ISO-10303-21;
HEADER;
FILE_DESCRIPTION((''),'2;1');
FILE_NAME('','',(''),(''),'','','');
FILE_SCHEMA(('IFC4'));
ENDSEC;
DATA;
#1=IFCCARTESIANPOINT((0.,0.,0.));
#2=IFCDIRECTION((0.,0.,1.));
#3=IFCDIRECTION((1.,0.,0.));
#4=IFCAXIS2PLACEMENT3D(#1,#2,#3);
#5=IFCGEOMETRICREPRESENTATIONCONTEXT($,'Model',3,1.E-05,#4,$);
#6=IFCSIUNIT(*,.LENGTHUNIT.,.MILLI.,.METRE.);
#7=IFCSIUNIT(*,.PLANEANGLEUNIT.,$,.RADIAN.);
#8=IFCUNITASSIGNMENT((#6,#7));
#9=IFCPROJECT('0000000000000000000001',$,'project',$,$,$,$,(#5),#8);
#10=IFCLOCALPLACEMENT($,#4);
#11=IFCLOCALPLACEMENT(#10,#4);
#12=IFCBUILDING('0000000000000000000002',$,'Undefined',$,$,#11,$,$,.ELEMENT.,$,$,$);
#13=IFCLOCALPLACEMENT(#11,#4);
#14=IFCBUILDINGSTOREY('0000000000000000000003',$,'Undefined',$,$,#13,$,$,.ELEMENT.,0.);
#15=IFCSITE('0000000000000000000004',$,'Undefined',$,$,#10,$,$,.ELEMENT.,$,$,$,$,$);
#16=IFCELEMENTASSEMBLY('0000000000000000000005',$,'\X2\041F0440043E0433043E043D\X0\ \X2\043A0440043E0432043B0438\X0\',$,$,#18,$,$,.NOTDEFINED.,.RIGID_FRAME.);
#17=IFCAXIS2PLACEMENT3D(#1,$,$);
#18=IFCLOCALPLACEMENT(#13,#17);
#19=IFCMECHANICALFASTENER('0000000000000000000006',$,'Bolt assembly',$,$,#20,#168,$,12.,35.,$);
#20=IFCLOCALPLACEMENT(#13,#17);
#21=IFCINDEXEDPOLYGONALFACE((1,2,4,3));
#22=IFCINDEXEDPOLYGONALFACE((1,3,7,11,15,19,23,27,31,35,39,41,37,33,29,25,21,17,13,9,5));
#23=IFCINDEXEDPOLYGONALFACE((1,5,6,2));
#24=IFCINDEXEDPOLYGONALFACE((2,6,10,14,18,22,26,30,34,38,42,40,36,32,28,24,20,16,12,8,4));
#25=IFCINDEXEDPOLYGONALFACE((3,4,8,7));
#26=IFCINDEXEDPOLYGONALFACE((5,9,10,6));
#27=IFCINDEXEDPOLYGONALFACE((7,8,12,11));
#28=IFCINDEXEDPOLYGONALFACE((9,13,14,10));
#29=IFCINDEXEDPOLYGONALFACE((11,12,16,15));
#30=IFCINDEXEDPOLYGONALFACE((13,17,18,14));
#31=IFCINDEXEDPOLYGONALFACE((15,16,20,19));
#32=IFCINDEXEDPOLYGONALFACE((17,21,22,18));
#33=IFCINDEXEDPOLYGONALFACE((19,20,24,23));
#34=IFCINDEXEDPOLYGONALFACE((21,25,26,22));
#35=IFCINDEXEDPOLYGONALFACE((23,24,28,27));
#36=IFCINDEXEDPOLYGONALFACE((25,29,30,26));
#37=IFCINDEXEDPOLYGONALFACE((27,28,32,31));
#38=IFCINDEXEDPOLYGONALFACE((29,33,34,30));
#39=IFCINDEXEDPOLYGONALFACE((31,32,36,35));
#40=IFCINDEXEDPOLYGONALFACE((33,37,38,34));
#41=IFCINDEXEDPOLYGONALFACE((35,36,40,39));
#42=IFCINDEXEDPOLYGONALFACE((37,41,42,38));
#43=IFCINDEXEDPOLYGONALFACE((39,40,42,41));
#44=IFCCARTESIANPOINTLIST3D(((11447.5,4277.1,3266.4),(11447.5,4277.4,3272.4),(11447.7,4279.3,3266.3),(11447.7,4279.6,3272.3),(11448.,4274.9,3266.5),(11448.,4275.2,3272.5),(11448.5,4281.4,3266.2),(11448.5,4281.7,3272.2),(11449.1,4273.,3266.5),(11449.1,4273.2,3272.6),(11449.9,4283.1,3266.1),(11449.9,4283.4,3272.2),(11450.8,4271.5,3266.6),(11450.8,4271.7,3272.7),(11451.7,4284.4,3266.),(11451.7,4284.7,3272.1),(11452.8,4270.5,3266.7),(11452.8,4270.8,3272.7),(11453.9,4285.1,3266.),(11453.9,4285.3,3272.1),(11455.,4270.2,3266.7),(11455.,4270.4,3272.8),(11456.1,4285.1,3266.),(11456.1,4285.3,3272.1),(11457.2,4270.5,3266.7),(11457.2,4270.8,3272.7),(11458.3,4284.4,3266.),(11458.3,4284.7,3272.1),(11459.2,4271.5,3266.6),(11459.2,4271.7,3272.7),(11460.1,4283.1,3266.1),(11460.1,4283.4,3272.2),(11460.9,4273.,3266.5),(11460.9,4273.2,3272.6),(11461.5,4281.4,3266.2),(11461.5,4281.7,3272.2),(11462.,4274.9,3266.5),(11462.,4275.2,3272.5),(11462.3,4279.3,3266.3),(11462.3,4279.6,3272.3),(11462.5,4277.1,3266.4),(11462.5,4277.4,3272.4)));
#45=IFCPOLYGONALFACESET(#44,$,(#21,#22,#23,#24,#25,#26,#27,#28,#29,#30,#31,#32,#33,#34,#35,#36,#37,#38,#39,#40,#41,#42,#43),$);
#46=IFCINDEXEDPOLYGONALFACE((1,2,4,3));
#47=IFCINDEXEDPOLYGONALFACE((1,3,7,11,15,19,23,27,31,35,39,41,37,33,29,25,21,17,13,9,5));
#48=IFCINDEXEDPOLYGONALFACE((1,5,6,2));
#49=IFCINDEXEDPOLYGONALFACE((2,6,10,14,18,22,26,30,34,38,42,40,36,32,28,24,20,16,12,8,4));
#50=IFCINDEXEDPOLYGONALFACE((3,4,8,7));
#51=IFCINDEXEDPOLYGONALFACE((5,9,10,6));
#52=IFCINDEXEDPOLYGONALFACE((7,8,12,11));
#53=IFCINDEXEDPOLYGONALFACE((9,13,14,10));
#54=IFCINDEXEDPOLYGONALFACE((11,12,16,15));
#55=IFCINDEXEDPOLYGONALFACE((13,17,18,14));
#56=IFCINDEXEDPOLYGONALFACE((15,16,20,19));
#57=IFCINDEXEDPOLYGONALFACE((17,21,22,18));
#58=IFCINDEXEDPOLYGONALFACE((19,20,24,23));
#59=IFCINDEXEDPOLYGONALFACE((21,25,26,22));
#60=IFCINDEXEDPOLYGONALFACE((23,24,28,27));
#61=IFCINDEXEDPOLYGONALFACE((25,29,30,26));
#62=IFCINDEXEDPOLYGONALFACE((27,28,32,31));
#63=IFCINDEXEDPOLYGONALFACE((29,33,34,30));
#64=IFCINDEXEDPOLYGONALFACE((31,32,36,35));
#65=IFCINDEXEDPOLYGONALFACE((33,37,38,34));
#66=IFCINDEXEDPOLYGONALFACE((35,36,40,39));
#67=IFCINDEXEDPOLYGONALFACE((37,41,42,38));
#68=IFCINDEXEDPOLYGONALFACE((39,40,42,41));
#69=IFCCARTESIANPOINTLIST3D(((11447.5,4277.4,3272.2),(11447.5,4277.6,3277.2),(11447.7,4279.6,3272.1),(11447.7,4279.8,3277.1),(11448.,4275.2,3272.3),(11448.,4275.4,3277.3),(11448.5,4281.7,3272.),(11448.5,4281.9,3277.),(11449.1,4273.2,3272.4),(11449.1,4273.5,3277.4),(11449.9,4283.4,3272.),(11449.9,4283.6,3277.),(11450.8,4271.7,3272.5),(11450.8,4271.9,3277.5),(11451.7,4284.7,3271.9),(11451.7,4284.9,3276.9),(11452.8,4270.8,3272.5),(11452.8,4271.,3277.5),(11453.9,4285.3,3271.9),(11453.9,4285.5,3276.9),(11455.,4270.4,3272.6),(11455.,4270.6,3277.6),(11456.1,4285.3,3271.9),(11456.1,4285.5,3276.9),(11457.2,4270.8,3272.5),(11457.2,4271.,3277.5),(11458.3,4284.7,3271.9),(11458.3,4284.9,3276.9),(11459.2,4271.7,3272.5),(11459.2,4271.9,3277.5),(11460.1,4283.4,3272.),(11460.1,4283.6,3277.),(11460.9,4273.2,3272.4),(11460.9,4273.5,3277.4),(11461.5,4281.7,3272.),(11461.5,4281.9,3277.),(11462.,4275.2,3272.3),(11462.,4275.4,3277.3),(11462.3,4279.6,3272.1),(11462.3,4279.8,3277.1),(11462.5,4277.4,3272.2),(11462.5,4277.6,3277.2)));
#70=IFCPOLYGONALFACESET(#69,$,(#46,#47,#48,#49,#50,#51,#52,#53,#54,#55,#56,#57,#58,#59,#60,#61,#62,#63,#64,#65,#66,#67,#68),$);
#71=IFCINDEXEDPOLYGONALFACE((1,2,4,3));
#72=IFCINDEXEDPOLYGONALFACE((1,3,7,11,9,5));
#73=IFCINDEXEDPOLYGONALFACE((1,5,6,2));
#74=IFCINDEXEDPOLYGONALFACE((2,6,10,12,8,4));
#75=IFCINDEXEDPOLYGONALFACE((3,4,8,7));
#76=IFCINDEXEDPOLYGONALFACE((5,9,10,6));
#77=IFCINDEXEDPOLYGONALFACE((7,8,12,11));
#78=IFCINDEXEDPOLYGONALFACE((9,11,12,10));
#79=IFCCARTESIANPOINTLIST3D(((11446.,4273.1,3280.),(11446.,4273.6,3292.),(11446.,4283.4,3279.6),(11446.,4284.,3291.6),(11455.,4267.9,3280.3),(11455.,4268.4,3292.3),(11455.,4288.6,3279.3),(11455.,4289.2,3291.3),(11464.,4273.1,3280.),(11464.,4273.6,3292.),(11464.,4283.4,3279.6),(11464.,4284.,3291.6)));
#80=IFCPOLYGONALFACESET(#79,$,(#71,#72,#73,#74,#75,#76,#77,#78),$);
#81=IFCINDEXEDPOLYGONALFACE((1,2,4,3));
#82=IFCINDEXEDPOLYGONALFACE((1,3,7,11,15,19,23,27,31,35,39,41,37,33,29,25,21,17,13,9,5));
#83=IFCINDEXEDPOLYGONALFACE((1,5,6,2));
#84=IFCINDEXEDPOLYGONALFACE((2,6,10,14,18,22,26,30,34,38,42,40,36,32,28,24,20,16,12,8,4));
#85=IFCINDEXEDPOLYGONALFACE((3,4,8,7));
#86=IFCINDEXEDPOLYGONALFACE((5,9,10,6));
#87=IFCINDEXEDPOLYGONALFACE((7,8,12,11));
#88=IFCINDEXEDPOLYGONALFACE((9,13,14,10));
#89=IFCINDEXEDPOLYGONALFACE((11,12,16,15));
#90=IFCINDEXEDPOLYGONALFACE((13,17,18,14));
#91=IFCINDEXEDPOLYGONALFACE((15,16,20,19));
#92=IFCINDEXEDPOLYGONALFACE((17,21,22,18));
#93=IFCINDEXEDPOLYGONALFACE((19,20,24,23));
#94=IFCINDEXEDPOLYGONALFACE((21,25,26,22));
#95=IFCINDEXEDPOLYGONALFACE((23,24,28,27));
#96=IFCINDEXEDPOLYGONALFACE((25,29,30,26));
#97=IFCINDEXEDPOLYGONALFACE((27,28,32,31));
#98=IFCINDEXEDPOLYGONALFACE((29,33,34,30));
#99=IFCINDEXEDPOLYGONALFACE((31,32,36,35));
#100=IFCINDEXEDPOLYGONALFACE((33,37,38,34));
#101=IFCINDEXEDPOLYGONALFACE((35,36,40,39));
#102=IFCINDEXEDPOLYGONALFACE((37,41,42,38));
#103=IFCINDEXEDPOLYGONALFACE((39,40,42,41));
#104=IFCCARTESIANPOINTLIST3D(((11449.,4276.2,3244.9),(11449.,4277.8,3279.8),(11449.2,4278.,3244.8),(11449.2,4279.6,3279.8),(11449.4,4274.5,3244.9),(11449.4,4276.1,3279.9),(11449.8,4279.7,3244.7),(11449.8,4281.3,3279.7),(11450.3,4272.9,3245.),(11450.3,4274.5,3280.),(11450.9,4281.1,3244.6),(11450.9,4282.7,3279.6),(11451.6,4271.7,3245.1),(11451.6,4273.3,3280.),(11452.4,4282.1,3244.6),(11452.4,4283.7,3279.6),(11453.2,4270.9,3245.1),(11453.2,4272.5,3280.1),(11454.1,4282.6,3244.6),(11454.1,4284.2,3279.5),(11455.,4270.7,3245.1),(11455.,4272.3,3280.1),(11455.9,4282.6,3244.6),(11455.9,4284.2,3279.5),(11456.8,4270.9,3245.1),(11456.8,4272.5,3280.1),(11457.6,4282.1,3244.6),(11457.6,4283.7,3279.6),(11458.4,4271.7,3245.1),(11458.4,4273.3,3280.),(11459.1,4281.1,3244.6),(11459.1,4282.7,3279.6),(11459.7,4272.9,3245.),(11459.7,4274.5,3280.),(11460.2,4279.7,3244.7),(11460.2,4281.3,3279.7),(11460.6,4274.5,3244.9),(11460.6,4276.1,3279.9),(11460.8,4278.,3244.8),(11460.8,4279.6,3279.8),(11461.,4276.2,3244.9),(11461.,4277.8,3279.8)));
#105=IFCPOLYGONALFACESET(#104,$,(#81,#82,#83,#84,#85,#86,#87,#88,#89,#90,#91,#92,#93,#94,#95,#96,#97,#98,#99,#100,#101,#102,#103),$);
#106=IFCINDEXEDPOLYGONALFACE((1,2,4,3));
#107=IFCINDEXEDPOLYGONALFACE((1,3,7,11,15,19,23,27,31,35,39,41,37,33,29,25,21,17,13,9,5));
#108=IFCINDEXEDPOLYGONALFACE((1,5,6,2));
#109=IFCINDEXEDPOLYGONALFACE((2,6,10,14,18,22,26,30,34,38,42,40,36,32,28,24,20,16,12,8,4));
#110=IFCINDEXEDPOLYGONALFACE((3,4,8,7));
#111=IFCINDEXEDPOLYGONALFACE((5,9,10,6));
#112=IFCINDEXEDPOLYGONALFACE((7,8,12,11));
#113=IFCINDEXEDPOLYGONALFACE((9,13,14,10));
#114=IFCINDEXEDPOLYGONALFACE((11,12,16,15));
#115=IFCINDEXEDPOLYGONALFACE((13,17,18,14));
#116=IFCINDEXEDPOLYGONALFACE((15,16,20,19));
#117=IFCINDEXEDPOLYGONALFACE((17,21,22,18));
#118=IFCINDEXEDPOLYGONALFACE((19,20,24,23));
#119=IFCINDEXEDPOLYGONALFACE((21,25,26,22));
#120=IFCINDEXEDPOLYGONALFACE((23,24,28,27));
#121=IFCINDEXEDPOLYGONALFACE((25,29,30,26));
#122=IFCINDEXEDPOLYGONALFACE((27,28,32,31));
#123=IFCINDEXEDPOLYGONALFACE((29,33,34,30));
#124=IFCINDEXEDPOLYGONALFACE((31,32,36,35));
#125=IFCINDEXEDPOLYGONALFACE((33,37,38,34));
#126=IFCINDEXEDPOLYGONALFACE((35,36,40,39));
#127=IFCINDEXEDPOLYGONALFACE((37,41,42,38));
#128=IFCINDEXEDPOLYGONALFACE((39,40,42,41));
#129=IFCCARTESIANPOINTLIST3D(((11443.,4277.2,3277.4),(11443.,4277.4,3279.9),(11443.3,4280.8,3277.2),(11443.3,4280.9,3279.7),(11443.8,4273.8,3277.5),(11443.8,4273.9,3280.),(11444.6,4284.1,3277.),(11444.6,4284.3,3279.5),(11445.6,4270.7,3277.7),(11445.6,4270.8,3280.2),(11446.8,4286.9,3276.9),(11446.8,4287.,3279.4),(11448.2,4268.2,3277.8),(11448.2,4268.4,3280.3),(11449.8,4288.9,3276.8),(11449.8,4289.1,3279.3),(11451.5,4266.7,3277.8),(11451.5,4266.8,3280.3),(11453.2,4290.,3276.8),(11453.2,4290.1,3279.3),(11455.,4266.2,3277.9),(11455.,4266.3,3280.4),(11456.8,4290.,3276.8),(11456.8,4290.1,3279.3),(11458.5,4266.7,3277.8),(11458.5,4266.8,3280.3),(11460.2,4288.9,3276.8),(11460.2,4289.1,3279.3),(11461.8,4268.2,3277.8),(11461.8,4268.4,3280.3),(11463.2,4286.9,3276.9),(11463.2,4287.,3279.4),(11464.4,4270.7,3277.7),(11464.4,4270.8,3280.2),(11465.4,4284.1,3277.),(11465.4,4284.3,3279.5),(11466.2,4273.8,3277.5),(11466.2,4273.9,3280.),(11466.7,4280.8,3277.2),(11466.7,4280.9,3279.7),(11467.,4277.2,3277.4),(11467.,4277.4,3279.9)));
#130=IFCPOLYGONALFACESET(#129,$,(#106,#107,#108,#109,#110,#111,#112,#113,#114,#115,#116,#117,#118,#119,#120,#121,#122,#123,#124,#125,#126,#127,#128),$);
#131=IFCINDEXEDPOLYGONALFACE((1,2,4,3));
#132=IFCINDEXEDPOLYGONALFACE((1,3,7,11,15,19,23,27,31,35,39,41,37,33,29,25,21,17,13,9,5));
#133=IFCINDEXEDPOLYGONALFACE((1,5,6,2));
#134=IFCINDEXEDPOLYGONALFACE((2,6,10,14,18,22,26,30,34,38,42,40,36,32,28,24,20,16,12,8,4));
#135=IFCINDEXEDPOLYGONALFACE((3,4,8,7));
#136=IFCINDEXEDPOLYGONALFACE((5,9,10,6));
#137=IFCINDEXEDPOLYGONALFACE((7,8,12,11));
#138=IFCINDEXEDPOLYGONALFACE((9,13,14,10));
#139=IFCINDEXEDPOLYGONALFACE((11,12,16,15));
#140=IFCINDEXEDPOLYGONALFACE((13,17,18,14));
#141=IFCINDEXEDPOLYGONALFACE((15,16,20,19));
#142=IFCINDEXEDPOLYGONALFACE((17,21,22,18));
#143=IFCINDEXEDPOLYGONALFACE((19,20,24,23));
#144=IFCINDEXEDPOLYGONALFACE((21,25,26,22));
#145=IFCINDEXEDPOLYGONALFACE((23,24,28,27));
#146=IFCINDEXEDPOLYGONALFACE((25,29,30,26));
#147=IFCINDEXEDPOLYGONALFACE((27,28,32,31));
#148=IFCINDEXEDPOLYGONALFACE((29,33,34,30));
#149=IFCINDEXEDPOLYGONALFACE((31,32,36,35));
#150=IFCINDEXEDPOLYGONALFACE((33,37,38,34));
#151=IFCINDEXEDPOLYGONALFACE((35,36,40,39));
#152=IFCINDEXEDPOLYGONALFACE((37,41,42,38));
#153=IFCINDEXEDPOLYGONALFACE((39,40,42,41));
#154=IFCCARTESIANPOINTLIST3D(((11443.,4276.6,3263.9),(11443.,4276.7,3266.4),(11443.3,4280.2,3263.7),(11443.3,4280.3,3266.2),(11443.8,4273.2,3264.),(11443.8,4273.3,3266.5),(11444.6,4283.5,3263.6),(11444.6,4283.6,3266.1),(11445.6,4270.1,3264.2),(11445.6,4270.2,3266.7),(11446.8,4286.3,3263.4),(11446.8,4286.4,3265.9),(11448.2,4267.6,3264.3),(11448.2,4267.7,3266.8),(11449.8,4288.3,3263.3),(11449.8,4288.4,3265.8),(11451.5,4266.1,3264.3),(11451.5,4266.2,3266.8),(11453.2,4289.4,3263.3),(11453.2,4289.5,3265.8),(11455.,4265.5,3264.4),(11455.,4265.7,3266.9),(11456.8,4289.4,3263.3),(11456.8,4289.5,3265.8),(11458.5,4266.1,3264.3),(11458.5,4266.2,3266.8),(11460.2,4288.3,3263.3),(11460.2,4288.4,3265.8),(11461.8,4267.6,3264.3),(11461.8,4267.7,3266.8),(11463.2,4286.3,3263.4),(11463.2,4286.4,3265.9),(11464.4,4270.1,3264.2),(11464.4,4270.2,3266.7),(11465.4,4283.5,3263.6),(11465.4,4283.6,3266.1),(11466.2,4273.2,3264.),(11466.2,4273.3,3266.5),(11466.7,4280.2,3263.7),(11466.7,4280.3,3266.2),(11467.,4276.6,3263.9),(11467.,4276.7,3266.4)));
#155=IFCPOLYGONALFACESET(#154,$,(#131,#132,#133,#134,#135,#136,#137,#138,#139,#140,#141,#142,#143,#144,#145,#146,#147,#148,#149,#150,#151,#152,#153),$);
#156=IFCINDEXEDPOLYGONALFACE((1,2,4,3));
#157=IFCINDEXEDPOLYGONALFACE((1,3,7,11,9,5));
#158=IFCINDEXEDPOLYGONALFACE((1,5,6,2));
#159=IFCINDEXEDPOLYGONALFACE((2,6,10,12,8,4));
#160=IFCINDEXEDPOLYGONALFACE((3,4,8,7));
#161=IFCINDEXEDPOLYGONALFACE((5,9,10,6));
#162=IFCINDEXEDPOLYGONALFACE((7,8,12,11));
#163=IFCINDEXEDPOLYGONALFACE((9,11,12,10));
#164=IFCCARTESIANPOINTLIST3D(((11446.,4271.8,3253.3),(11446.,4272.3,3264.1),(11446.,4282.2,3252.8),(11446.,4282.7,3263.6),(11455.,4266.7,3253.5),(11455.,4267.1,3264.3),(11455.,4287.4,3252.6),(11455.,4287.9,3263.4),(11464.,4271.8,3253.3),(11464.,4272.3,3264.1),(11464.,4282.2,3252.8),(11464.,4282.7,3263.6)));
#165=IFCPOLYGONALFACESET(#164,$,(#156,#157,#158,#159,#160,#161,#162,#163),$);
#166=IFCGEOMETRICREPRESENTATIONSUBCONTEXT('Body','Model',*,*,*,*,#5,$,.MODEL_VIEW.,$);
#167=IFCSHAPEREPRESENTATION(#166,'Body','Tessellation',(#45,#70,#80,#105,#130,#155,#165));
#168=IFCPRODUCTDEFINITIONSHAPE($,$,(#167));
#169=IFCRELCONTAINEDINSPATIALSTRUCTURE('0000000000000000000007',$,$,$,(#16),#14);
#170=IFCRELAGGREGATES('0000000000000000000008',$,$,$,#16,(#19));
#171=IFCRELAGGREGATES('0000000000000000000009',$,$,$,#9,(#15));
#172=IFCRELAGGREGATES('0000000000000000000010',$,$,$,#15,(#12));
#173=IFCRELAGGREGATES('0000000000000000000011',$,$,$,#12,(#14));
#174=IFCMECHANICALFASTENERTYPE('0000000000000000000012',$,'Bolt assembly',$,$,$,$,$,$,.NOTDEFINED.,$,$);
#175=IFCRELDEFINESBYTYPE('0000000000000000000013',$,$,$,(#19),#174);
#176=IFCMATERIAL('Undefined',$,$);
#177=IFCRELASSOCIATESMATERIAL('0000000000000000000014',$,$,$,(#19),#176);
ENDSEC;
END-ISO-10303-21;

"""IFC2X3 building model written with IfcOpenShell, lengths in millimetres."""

from ifc_helpers import new_model, si_unit, frame, origin_with_axes, origin_2d_with_axis, place, context, subcontext, project, spatial, polyline, circle, outline, extrude, source, transform, mapped, material, type_object, element, aggregate, save


model = new_model("IFC2X3")

# Units and contexts
model_context = context("Model", 3, precision=1e-05, world=origin_with_axes())
body_context = subcontext(model_context, "Body", "Model", "MODEL_VIEW")
ifc_project = project(units=[si_unit("LENGTHUNIT", "METRE", prefix="MILLI"), si_unit("PLANEANGLEUNIT", "RADIAN")], contexts=[model_context])

# Site, building, storey
site_placement = place(None, origin_with_axes())
site = spatial("IfcSite", under=ifc_project, at=site_placement, Name="Undefined", CompositionType="ELEMENT")
building_placement = place(site_placement, origin_with_axes())
building = spatial("IfcBuilding", under=site, at=building_placement, Name="Undefined", CompositionType="ELEMENT")
storey_placement = place(building_placement, origin_with_axes())
storey = spatial("IfcBuildingStorey", under=building, at=storey_placement, Name="Undefined", CompositionType="ELEMENT", Elevation=0.0)

# Element assembly
assembly_1_placement = place(storey_placement, origin_with_axes())
assembly_1 = element("IfcElementAssembly", 1, at=assembly_1_placement, inside=storey, Name="Прогон кровли", AssemblyPlace="NOTDEFINED", PredefinedType="RIGID_FRAME")

# Mechanical fastener
ifc_material_1 = material(Name="Undefined")
mechanical_fastener_type = type_object("IfcMechanicalFastenerType", Name="Bolt assembly")
shared_shape_1 = source(origin_with_axes(), body_context, "Body", "SweptSolid", [
    extrude(circle(Radius=7.5, at=origin_2d_with_axis()), frame((0.0, -0.1, 0.0), z_axis=(0.0, 1.0, 0.0), x_axis=(1.0, 0.0, 0.0)), (0.0, 0.0, 1.0), 6.1),
    extrude(circle(Radius=7.5, at=origin_2d_with_axis()), frame((0.0, -4.9, 0.0), z_axis=(0.0, 1.0, 0.0), x_axis=(1.0, 0.0, 0.0)), (0.0, 0.0, 1.0), 5.0),
    extrude(outline(polyline([(10.4, 0.0), (5.2, 9.0), (-5.2, 9.0), (-10.4, 0.0), (-5.2, -9.0), (5.2, -9.0), (10.4, 0.0)])), frame((0.0, -19.5, 0.0), z_axis=(0.0, 1.0, 0.0), x_axis=(1.0, 0.0, 0.0)), (0.0, 0.0, 1.0), 12.0),
    extrude(circle(Radius=6.0, at=origin_2d_with_axis()), frame((0.0, -7.5, 0.0), z_axis=(0.0, 1.0, 0.0), x_axis=(1.0, 0.0, 0.0)), (0.0, 0.0, 1.0), 35.0),
    extrude(circle(Radius=12.0, at=origin_2d_with_axis()), frame((0.0, -7.5, 0.0), z_axis=(0.0, 1.0, 0.0), x_axis=(1.0, 0.0, 0.0)), (0.0, 0.0, 1.0), 2.5),
    extrude(circle(Radius=12.0, at=origin_2d_with_axis()), frame((0.0, 6.0, 0.0), z_axis=(0.0, 1.0, 0.0), x_axis=(1.0, 0.0, 0.0)), (0.0, 0.0, 1.0), 2.5),
    extrude(outline(polyline([(10.4, 0.0), (5.2, 9.0), (-5.2, 9.0), (-10.4, 0.0), (-5.2, -9.0), (5.2, -9.0), (10.4, 0.0)])), frame((0.0, 8.5, 0.0), z_axis=(0.0, 1.0, 0.0), x_axis=(1.0, 0.0, 0.0)), (0.0, 0.0, 1.0), 10.8),
])
mechanical_fastener_1_placement = place(assembly_1_placement, frame((11455.0, 4277.9, 3272.3), z_axis=(1.0, 0.0, 0.0), x_axis=(0.0, -0.998969, 0.045408)))
mechanical_fastener_1 = element("IfcMechanicalFastener", 2, at=mechanical_fastener_1_placement, type_object=mechanical_fastener_type, material=ifc_material_1, Name="Bolt assembly", NominalDiameter=12.0, NominalLength=35.0, context=body_context, shape_type="MappedRepresentation", body=[
    mapped(shared_shape_1, transform((0.0, 0.0, 0.0))),
])
aggregate(assembly_1, [mechanical_fastener_1])

save(model, "model.ifc")
